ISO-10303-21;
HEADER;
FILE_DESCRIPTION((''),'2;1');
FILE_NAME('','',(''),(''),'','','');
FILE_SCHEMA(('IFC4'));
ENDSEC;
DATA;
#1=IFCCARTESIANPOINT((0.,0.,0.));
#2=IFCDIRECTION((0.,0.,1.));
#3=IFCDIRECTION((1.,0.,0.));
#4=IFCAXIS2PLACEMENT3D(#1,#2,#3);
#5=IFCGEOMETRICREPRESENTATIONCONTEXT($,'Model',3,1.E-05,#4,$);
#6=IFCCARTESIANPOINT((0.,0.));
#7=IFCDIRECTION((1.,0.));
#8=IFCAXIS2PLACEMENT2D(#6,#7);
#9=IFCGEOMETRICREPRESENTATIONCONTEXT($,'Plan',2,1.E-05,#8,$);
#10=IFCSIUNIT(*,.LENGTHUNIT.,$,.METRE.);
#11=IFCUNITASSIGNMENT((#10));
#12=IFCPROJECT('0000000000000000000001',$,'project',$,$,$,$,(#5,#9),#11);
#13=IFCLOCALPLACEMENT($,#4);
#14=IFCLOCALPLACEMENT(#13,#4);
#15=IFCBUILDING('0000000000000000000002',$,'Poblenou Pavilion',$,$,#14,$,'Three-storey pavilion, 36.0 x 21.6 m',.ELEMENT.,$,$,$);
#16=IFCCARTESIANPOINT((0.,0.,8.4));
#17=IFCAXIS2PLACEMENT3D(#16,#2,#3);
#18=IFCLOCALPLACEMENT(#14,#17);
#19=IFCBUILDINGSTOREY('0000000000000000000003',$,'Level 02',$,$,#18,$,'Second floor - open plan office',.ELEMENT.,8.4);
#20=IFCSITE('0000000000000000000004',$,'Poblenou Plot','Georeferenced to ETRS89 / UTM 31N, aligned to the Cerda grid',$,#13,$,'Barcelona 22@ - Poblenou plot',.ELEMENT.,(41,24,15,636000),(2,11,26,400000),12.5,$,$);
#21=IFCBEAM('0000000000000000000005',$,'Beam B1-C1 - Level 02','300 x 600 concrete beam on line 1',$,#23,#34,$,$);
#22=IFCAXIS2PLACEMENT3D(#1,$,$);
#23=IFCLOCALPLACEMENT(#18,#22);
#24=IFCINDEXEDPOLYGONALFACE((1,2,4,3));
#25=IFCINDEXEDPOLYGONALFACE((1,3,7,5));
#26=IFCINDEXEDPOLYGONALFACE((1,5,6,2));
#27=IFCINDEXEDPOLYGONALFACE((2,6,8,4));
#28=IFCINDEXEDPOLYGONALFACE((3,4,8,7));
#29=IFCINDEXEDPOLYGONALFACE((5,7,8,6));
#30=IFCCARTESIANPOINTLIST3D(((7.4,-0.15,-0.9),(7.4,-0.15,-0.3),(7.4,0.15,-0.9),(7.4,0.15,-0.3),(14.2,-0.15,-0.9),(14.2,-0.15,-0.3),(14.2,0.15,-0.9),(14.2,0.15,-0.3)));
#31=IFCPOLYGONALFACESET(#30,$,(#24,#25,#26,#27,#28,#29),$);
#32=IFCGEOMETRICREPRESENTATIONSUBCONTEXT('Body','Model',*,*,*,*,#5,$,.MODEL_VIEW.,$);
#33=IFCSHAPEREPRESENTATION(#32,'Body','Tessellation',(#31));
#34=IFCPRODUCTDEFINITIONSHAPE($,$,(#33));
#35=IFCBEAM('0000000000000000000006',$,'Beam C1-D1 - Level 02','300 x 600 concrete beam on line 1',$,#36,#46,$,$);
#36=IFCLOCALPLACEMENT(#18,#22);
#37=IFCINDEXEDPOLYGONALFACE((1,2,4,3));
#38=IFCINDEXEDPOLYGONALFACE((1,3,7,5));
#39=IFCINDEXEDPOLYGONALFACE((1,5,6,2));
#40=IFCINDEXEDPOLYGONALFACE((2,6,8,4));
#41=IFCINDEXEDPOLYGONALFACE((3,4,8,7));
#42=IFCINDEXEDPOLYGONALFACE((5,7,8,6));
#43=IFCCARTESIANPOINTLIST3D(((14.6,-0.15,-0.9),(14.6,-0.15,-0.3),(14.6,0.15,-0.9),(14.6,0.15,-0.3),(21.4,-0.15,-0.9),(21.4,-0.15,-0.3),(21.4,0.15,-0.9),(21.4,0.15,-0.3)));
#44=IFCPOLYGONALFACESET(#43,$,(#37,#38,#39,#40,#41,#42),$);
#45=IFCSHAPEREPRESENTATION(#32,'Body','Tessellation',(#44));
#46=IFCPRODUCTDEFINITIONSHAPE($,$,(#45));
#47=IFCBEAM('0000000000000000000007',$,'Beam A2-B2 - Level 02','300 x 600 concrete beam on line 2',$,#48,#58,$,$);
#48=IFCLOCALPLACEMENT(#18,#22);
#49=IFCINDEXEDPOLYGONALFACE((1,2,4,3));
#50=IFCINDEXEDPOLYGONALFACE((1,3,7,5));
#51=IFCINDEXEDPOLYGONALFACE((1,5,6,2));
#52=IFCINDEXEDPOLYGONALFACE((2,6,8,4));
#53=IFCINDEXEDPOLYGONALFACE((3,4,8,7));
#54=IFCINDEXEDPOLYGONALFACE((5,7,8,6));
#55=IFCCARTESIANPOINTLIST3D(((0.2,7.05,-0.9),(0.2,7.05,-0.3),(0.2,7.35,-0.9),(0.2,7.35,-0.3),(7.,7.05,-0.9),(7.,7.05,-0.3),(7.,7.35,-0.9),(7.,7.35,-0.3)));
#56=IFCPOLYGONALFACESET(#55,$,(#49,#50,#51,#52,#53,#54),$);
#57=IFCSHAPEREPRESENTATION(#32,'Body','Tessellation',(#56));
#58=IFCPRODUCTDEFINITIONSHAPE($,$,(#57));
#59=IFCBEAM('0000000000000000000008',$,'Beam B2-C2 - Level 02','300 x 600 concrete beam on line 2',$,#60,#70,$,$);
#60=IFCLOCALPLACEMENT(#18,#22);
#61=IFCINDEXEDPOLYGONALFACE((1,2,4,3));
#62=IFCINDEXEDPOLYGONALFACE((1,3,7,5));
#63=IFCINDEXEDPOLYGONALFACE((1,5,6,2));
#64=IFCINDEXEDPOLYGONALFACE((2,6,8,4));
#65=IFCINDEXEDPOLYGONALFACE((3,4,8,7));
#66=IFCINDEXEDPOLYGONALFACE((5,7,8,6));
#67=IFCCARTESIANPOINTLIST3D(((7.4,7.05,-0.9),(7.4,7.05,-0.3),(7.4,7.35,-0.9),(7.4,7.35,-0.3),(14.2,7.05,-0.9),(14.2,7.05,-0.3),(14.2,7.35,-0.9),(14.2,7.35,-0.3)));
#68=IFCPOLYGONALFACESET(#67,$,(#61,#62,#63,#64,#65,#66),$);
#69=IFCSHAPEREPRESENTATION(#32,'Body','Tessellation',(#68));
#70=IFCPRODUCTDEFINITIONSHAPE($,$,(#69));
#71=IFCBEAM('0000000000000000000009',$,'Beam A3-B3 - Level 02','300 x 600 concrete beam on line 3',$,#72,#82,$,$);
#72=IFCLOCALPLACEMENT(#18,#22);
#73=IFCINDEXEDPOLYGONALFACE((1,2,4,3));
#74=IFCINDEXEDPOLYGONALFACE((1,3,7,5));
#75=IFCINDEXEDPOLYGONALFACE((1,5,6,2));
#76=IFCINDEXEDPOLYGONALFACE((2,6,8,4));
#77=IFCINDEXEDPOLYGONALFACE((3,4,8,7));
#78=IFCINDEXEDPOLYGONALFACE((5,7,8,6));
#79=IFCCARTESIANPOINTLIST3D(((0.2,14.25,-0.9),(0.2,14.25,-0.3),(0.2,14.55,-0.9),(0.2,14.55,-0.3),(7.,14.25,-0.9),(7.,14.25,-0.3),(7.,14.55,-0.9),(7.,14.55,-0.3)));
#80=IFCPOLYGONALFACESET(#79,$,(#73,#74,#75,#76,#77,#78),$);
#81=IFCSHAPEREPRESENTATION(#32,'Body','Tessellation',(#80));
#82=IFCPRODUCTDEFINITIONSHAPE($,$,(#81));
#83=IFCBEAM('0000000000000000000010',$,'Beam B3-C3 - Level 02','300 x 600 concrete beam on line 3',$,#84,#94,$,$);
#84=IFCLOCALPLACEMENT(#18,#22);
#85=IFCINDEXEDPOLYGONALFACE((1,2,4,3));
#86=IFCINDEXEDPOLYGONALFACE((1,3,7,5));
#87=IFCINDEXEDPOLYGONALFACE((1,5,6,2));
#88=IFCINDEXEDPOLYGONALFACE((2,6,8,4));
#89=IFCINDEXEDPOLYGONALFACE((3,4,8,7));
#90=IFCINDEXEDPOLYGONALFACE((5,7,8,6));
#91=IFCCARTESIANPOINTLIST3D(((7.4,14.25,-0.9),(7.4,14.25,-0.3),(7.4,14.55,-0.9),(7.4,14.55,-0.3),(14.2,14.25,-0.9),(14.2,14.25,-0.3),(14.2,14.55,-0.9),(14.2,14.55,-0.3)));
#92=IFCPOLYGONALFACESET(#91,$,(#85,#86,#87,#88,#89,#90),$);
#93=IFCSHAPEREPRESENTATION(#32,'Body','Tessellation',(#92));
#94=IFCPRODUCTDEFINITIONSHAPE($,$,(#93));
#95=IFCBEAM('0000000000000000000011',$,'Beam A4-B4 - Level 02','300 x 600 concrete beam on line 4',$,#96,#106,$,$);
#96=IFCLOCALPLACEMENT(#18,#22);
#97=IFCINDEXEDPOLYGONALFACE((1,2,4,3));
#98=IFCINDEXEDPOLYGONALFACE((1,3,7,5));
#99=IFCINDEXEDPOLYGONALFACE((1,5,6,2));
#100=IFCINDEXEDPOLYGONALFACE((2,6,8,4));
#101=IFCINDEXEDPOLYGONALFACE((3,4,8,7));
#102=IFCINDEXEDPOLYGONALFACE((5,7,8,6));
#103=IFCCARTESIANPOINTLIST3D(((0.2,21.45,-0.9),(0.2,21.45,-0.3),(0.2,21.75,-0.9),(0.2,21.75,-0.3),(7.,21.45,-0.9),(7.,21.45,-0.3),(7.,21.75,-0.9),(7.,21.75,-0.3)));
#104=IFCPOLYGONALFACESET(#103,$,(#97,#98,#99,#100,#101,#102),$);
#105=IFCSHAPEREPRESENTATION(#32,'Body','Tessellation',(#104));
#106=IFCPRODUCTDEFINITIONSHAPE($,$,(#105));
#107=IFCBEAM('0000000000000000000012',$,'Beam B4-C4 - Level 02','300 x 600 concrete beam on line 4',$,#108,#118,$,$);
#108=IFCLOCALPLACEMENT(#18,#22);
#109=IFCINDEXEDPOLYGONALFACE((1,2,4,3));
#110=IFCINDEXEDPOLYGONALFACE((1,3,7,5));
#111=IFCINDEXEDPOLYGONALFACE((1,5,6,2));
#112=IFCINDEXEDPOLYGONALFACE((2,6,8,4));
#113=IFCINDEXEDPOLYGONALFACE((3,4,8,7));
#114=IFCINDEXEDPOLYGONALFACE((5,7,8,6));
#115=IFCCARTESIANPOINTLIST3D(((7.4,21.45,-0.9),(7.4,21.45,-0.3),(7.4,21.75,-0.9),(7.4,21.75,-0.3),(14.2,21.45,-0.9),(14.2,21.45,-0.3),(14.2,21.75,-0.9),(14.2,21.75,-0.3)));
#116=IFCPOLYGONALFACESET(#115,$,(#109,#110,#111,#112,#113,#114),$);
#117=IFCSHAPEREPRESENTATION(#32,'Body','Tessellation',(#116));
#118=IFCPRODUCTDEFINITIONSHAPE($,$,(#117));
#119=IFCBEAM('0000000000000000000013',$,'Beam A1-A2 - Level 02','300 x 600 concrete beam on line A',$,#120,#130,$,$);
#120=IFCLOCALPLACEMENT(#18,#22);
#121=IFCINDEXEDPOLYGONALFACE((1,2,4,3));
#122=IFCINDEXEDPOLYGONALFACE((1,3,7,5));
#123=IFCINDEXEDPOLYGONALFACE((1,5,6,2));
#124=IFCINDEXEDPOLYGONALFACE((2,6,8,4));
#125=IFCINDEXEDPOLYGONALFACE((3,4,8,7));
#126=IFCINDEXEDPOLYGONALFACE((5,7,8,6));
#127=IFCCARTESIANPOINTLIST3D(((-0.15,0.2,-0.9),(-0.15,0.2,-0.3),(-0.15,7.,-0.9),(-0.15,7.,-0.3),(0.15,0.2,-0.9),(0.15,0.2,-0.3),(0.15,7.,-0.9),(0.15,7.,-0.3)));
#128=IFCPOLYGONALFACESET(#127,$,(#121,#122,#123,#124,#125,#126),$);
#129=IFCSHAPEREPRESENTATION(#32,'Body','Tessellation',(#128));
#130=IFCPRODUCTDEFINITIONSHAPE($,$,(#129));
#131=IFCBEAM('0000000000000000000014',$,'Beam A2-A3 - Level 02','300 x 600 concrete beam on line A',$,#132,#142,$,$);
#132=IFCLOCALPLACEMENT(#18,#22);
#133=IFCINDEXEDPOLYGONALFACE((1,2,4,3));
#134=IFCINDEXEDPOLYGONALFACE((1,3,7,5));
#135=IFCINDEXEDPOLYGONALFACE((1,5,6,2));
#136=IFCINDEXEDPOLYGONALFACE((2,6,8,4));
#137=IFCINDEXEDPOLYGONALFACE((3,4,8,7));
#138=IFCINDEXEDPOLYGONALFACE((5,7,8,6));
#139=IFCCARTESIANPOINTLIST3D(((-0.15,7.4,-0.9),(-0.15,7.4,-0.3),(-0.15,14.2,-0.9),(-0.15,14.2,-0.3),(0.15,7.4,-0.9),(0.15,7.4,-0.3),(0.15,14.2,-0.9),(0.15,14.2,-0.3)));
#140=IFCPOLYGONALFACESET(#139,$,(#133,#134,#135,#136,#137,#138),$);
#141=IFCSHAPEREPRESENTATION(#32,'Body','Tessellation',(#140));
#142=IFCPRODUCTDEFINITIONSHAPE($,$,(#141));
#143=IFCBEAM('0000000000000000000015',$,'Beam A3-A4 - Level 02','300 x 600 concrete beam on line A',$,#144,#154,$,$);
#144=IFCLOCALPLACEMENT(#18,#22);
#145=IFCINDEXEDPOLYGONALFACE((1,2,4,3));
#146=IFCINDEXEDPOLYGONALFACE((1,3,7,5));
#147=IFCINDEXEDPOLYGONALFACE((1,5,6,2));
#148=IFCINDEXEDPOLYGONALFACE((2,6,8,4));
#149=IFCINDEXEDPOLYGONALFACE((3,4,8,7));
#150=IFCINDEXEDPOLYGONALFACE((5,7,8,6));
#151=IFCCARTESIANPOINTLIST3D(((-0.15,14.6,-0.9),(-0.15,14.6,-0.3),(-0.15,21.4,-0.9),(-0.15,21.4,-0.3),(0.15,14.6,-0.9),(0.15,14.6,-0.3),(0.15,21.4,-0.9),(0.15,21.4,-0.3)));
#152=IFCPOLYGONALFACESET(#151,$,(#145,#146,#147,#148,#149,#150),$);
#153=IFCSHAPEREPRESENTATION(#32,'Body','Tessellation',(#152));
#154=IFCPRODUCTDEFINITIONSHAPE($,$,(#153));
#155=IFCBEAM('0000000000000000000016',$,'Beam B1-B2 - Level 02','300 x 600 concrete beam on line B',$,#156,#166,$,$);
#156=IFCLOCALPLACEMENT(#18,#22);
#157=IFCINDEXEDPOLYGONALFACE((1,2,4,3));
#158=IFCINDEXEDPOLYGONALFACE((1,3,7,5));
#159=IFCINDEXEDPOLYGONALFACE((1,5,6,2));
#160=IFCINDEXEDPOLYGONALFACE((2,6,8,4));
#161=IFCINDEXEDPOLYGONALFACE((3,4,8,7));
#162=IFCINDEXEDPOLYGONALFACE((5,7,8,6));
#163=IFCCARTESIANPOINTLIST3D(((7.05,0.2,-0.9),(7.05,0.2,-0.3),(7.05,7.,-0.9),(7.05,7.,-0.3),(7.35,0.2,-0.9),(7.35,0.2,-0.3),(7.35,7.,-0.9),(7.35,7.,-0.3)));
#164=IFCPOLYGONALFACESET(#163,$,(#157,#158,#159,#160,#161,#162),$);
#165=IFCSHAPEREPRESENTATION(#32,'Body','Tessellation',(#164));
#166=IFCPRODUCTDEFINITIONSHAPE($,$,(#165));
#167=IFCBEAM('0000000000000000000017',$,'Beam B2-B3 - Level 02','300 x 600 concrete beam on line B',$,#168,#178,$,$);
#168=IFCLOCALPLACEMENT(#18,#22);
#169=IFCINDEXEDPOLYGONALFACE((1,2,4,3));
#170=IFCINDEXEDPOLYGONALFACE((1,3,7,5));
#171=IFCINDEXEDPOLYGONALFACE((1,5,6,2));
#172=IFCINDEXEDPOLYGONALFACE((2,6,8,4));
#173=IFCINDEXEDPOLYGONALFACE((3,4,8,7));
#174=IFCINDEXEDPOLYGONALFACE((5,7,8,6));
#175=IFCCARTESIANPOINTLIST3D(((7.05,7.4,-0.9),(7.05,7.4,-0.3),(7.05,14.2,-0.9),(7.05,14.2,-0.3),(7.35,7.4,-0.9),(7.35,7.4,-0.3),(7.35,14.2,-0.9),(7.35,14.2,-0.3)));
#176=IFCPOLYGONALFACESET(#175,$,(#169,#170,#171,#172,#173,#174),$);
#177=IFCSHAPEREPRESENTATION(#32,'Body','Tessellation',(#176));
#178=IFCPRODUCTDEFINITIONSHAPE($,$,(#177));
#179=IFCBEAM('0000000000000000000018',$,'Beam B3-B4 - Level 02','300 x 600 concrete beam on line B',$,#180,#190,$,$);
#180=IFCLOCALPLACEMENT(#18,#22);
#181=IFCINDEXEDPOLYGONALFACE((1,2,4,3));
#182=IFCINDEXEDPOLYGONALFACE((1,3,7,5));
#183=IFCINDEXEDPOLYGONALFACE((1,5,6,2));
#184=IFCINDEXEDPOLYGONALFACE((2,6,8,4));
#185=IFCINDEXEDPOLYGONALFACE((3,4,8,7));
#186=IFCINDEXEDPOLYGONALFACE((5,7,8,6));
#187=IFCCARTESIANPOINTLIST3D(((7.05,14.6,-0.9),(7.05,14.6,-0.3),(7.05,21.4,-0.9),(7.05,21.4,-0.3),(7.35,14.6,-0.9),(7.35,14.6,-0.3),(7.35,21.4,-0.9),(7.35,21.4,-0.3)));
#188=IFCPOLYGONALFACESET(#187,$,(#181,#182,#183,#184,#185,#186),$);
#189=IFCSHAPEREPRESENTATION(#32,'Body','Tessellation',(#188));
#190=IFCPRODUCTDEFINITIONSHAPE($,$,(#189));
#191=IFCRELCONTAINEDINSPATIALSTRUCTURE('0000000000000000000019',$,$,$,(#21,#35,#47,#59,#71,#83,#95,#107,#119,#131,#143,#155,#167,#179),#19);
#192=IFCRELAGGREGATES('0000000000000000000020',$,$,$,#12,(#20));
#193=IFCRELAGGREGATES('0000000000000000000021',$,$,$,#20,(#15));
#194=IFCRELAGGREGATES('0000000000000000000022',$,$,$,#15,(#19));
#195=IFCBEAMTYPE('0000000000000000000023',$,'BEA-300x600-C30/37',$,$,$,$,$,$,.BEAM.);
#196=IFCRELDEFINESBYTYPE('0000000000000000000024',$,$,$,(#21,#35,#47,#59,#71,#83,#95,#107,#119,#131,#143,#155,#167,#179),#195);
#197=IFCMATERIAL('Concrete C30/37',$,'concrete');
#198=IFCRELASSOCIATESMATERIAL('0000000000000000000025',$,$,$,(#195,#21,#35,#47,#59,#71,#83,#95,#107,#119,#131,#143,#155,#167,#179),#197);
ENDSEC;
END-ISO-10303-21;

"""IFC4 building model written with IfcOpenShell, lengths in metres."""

from ifc_helpers import new_model, si_unit, frame, origin_with_axes, origin_2d_with_axis, place, context, subcontext, project, spatial, line, indexed_curve, rectangle, outline, extrude, material, material_profile, profile_set, profile_usage, type_object, element, save


model = new_model("IFC4")

# Units and contexts
model_context = context("Model", 3, precision=1e-05, world=origin_with_axes())
plan_context = context("Plan", 2, precision=1e-05, world=origin_2d_with_axis())
body_context = subcontext(model_context, "Body", "Model", "MODEL_VIEW")
ifc_project = project(units=[si_unit("LENGTHUNIT", "METRE")], contexts=[model_context, plan_context])

# Site, building, storey
site_placement = place(None, origin_with_axes())
site = spatial("IfcSite", under=ifc_project, at=site_placement, Name="Poblenou Plot", Description="Georeferenced to ETRS89 / UTM 31N, aligned to the Cerda grid", LongName="Barcelona 22@ - Poblenou plot", CompositionType="ELEMENT", RefLatitude=(41, 24, 15, 636000), RefLongitude=(2, 11, 26, 400000), RefElevation=12.5)
building_placement = place(site_placement, origin_with_axes())
building = spatial("IfcBuilding", under=site, at=building_placement, Name="Poblenou Pavilion", LongName="Three-storey pavilion, 36.0 x 21.6 m", CompositionType="ELEMENT")
storey_placement = place(building_placement, frame((0.0, 0.0, 8.4), z_axis=(0.0, 0.0, 1.0), x_axis=(1.0, 0.0, 0.0)))
storey = spatial("IfcBuildingStorey", under=building, at=storey_placement, Name="Level 02", LongName="Second floor - open plan office", CompositionType="ELEMENT", Elevation=8.4)

# Shared definitions
ifc_material = material(Name="Concrete C30/37", Category="concrete")

# Beams
ifc_material_profile_1 = material_profile(ifc_material, rectangle(XDim=0.3, YDim=0.6))
ifc_profile_set_1 = profile_set([ifc_material_profile_1], Name="BEA-300x600-C30/37")
beam_type = type_object("IfcBeamType", Name="BEA-300x600-C30/37", PredefinedType="BEAM", material=ifc_profile_set_1)
ifc_profile_usage_1 = profile_usage(ifc_profile_set_1)
beam_1_placement = place(storey_placement, frame((7.4, -0.15, -0.9), z_axis=(1.0, 0.0, 0.0), x_axis=(0.0, 1.0, 0.0)))
element("IfcBeam", 1, at=beam_1_placement, inside=storey, type_object=beam_type, material=ifc_profile_usage_1, Name="Beam B1-C1 - Level 02", Description="300 x 600 concrete beam on line 1", context=body_context, shape_type="SweptSolid", body=[
    extrude(outline(indexed_curve([(0.0, 0.0), (0.3, 0.0), (0.3, 0.6), (0.0, 0.6)], segments=[line(1, 2, 3, 4, 1)])), origin_with_axes(), (0.0, 0.0, 1.0), 6.8),
])
ifc_profile_usage_2 = profile_usage(ifc_profile_set_1)
beam_2_placement = place(storey_placement, frame((14.6, -0.15, -0.9), z_axis=(1.0, 0.0, 0.0), x_axis=(0.0, 1.0, 0.0)))
element("IfcBeam", 2, at=beam_2_placement, inside=storey, type_object=beam_type, material=ifc_profile_usage_2, Name="Beam C1-D1 - Level 02", Description="300 x 600 concrete beam on line 1", context=body_context, shape_type="SweptSolid", body=[
    extrude(outline(indexed_curve([(0.0, 0.0), (0.3, 0.0), (0.3, 0.6), (0.0, 0.6)], segments=[line(1, 2, 3, 4, 1)])), origin_with_axes(), (0.0, 0.0, 1.0), 6.8),
])
ifc_profile_usage_3 = profile_usage(ifc_profile_set_1)
beam_3_placement = place(storey_placement, frame((0.2, 7.05, -0.9), z_axis=(1.0, 0.0, 0.0), x_axis=(0.0, 1.0, 0.0)))
element("IfcBeam", 3, at=beam_3_placement, inside=storey, type_object=beam_type, material=ifc_profile_usage_3, Name="Beam A2-B2 - Level 02", Description="300 x 600 concrete beam on line 2", context=body_context, shape_type="SweptSolid", body=[
    extrude(outline(indexed_curve([(0.0, 0.0), (0.3, 0.0), (0.3, 0.6), (0.0, 0.6)], segments=[line(1, 2, 3, 4, 1)])), origin_with_axes(), (0.0, 0.0, 1.0), 6.8),
])
ifc_profile_usage_4 = profile_usage(ifc_profile_set_1)
beam_4_placement = place(storey_placement, frame((7.4, 7.05, -0.9), z_axis=(1.0, 0.0, 0.0), x_axis=(0.0, 1.0, 0.0)))
element("IfcBeam", 4, at=beam_4_placement, inside=storey, type_object=beam_type, material=ifc_profile_usage_4, Name="Beam B2-C2 - Level 02", Description="300 x 600 concrete beam on line 2", context=body_context, shape_type="SweptSolid", body=[
    extrude(outline(indexed_curve([(0.0, 0.0), (0.3, 0.0), (0.3, 0.6), (0.0, 0.6)], segments=[line(1, 2, 3, 4, 1)])), origin_with_axes(), (0.0, 0.0, 1.0), 6.8),
])
ifc_profile_usage_5 = profile_usage(ifc_profile_set_1)
beam_5_placement = place(storey_placement, frame((0.2, 14.25, -0.9), z_axis=(1.0, 0.0, 0.0), x_axis=(0.0, 1.0, 0.0)))
element("IfcBeam", 5, at=beam_5_placement, inside=storey, type_object=beam_type, material=ifc_profile_usage_5, Name="Beam A3-B3 - Level 02", Description="300 x 600 concrete beam on line 3", context=body_context, shape_type="SweptSolid", body=[
    extrude(outline(indexed_curve([(0.0, 0.0), (0.3, 0.0), (0.3, 0.6), (0.0, 0.6)], segments=[line(1, 2, 3, 4, 1)])), origin_with_axes(), (0.0, 0.0, 1.0), 6.8),
])
ifc_profile_usage_6 = profile_usage(ifc_profile_set_1)
beam_6_placement = place(storey_placement, frame((7.4, 14.25, -0.9), z_axis=(1.0, 0.0, 0.0), x_axis=(0.0, 1.0, 0.0)))
element("IfcBeam", 6, at=beam_6_placement, inside=storey, type_object=beam_type, material=ifc_profile_usage_6, Name="Beam B3-C3 - Level 02", Description="300 x 600 concrete beam on line 3", context=body_context, shape_type="SweptSolid", body=[
    extrude(outline(indexed_curve([(0.0, 0.0), (0.3, 0.0), (0.3, 0.6), (0.0, 0.6)], segments=[line(1, 2, 3, 4, 1)])), origin_with_axes(), (0.0, 0.0, 1.0), 6.8),
])
ifc_profile_usage_7 = profile_usage(ifc_profile_set_1)
beam_7_placement = place(storey_placement, frame((0.2, 21.45, -0.9), z_axis=(1.0, 0.0, 0.0), x_axis=(0.0, 1.0, 0.0)))
element("IfcBeam", 7, at=beam_7_placement, inside=storey, type_object=beam_type, material=ifc_profile_usage_7, Name="Beam A4-B4 - Level 02", Description="300 x 600 concrete beam on line 4", context=body_context, shape_type="SweptSolid", body=[
    extrude(outline(indexed_curve([(0.0, 0.0), (0.3, 0.0), (0.3, 0.6), (0.0, 0.6)], segments=[line(1, 2, 3, 4, 1)])), origin_with_axes(), (0.0, 0.0, 1.0), 6.8),
])
ifc_profile_usage_8 = profile_usage(ifc_profile_set_1)
beam_8_placement = place(storey_placement, frame((7.4, 21.45, -0.9), z_axis=(1.0, 0.0, 0.0), x_axis=(0.0, 1.0, 0.0)))
element("IfcBeam", 8, at=beam_8_placement, inside=storey, type_object=beam_type, material=ifc_profile_usage_8, Name="Beam B4-C4 - Level 02", Description="300 x 600 concrete beam on line 4", context=body_context, shape_type="SweptSolid", body=[
    extrude(outline(indexed_curve([(0.0, 0.0), (0.3, 0.0), (0.3, 0.6), (0.0, 0.6)], segments=[line(1, 2, 3, 4, 1)])), origin_with_axes(), (0.0, 0.0, 1.0), 6.8),
])
ifc_profile_usage_9 = profile_usage(ifc_profile_set_1)
beam_9_placement = place(storey_placement, frame((-0.15, 0.2, -0.9), z_axis=(0.0, 1.0, 0.0), x_axis=(0.0, 0.0, 1.0)))
element("IfcBeam", 9, at=beam_9_placement, inside=storey, type_object=beam_type, material=ifc_profile_usage_9, Name="Beam A1-A2 - Level 02", Description="300 x 600 concrete beam on line A", context=body_context, shape_type="SweptSolid", body=[
    extrude(outline(indexed_curve([(0.0, 0.0), (0.6, 0.0), (0.6, 0.3), (0.0, 0.3)], segments=[line(1, 2, 3, 4, 1)])), origin_with_axes(), (0.0, 0.0, 1.0), 6.8),
])
ifc_profile_usage_10 = profile_usage(ifc_profile_set_1)
beam_10_placement = place(storey_placement, frame((-0.15, 7.4, -0.9), z_axis=(0.0, 1.0, 0.0), x_axis=(0.0, 0.0, 1.0)))
element("IfcBeam", 10, at=beam_10_placement, inside=storey, type_object=beam_type, material=ifc_profile_usage_10, Name="Beam A2-A3 - Level 02", Description="300 x 600 concrete beam on line A", context=body_context, shape_type="SweptSolid", body=[
    extrude(outline(indexed_curve([(0.0, 0.0), (0.6, 0.0), (0.6, 0.3), (0.0, 0.3)], segments=[line(1, 2, 3, 4, 1)])), origin_with_axes(), (0.0, 0.0, 1.0), 6.8),
])
ifc_profile_usage_11 = profile_usage(ifc_profile_set_1)
beam_11_placement = place(storey_placement, frame((-0.15, 14.6, -0.9), z_axis=(0.0, 1.0, 0.0), x_axis=(0.0, 0.0, 1.0)))
element("IfcBeam", 11, at=beam_11_placement, inside=storey, type_object=beam_type, material=ifc_profile_usage_11, Name="Beam A3-A4 - Level 02", Description="300 x 600 concrete beam on line A", context=body_context, shape_type="SweptSolid", body=[
    extrude(outline(indexed_curve([(0.0, 0.0), (0.6, 0.0), (0.6, 0.3), (0.0, 0.3)], segments=[line(1, 2, 3, 4, 1)])), origin_with_axes(), (0.0, 0.0, 1.0), 6.8),
])
ifc_profile_usage_12 = profile_usage(ifc_profile_set_1)
beam_12_placement = place(storey_placement, frame((7.05, 0.2, -0.9), z_axis=(0.0, 1.0, 0.0), x_axis=(0.0, 0.0, 1.0)))
element("IfcBeam", 12, at=beam_12_placement, inside=storey, type_object=beam_type, material=ifc_profile_usage_12, Name="Beam B1-B2 - Level 02", Description="300 x 600 concrete beam on line B", context=body_context, shape_type="SweptSolid", body=[
    extrude(outline(indexed_curve([(0.0, 0.0), (0.6, 0.0), (0.6, 0.3), (0.0, 0.3)], segments=[line(1, 2, 3, 4, 1)])), origin_with_axes(), (0.0, 0.0, 1.0), 6.8),
])
ifc_profile_usage_13 = profile_usage(ifc_profile_set_1)
beam_13_placement = place(storey_placement, frame((7.05, 7.4, -0.9), z_axis=(0.0, 1.0, 0.0), x_axis=(0.0, 0.0, 1.0)))
element("IfcBeam", 13, at=beam_13_placement, inside=storey, type_object=beam_type, material=ifc_profile_usage_13, Name="Beam B2-B3 - Level 02", Description="300 x 600 concrete beam on line B", context=body_context, shape_type="SweptSolid", body=[
    extrude(outline(indexed_curve([(0.0, 0.0), (0.6, 0.0), (0.6, 0.3), (0.0, 0.3)], segments=[line(1, 2, 3, 4, 1)])), origin_with_axes(), (0.0, 0.0, 1.0), 6.8),
])
ifc_profile_usage_14 = profile_usage(ifc_profile_set_1)
beam_14_placement = place(storey_placement, frame((7.05, 14.6, -0.9), z_axis=(0.0, 1.0, 0.0), x_axis=(0.0, 0.0, 1.0)))
element("IfcBeam", 14, at=beam_14_placement, inside=storey, type_object=beam_type, material=ifc_profile_usage_14, Name="Beam B3-B4 - Level 02", Description="300 x 600 concrete beam on line B", context=body_context, shape_type="SweptSolid", body=[
    extrude(outline(indexed_curve([(0.0, 0.0), (0.6, 0.0), (0.6, 0.3), (0.0, 0.3)], segments=[line(1, 2, 3, 4, 1)])), origin_with_axes(), (0.0, 0.0, 1.0), 6.8),
])

save(model, "model.ifc")
